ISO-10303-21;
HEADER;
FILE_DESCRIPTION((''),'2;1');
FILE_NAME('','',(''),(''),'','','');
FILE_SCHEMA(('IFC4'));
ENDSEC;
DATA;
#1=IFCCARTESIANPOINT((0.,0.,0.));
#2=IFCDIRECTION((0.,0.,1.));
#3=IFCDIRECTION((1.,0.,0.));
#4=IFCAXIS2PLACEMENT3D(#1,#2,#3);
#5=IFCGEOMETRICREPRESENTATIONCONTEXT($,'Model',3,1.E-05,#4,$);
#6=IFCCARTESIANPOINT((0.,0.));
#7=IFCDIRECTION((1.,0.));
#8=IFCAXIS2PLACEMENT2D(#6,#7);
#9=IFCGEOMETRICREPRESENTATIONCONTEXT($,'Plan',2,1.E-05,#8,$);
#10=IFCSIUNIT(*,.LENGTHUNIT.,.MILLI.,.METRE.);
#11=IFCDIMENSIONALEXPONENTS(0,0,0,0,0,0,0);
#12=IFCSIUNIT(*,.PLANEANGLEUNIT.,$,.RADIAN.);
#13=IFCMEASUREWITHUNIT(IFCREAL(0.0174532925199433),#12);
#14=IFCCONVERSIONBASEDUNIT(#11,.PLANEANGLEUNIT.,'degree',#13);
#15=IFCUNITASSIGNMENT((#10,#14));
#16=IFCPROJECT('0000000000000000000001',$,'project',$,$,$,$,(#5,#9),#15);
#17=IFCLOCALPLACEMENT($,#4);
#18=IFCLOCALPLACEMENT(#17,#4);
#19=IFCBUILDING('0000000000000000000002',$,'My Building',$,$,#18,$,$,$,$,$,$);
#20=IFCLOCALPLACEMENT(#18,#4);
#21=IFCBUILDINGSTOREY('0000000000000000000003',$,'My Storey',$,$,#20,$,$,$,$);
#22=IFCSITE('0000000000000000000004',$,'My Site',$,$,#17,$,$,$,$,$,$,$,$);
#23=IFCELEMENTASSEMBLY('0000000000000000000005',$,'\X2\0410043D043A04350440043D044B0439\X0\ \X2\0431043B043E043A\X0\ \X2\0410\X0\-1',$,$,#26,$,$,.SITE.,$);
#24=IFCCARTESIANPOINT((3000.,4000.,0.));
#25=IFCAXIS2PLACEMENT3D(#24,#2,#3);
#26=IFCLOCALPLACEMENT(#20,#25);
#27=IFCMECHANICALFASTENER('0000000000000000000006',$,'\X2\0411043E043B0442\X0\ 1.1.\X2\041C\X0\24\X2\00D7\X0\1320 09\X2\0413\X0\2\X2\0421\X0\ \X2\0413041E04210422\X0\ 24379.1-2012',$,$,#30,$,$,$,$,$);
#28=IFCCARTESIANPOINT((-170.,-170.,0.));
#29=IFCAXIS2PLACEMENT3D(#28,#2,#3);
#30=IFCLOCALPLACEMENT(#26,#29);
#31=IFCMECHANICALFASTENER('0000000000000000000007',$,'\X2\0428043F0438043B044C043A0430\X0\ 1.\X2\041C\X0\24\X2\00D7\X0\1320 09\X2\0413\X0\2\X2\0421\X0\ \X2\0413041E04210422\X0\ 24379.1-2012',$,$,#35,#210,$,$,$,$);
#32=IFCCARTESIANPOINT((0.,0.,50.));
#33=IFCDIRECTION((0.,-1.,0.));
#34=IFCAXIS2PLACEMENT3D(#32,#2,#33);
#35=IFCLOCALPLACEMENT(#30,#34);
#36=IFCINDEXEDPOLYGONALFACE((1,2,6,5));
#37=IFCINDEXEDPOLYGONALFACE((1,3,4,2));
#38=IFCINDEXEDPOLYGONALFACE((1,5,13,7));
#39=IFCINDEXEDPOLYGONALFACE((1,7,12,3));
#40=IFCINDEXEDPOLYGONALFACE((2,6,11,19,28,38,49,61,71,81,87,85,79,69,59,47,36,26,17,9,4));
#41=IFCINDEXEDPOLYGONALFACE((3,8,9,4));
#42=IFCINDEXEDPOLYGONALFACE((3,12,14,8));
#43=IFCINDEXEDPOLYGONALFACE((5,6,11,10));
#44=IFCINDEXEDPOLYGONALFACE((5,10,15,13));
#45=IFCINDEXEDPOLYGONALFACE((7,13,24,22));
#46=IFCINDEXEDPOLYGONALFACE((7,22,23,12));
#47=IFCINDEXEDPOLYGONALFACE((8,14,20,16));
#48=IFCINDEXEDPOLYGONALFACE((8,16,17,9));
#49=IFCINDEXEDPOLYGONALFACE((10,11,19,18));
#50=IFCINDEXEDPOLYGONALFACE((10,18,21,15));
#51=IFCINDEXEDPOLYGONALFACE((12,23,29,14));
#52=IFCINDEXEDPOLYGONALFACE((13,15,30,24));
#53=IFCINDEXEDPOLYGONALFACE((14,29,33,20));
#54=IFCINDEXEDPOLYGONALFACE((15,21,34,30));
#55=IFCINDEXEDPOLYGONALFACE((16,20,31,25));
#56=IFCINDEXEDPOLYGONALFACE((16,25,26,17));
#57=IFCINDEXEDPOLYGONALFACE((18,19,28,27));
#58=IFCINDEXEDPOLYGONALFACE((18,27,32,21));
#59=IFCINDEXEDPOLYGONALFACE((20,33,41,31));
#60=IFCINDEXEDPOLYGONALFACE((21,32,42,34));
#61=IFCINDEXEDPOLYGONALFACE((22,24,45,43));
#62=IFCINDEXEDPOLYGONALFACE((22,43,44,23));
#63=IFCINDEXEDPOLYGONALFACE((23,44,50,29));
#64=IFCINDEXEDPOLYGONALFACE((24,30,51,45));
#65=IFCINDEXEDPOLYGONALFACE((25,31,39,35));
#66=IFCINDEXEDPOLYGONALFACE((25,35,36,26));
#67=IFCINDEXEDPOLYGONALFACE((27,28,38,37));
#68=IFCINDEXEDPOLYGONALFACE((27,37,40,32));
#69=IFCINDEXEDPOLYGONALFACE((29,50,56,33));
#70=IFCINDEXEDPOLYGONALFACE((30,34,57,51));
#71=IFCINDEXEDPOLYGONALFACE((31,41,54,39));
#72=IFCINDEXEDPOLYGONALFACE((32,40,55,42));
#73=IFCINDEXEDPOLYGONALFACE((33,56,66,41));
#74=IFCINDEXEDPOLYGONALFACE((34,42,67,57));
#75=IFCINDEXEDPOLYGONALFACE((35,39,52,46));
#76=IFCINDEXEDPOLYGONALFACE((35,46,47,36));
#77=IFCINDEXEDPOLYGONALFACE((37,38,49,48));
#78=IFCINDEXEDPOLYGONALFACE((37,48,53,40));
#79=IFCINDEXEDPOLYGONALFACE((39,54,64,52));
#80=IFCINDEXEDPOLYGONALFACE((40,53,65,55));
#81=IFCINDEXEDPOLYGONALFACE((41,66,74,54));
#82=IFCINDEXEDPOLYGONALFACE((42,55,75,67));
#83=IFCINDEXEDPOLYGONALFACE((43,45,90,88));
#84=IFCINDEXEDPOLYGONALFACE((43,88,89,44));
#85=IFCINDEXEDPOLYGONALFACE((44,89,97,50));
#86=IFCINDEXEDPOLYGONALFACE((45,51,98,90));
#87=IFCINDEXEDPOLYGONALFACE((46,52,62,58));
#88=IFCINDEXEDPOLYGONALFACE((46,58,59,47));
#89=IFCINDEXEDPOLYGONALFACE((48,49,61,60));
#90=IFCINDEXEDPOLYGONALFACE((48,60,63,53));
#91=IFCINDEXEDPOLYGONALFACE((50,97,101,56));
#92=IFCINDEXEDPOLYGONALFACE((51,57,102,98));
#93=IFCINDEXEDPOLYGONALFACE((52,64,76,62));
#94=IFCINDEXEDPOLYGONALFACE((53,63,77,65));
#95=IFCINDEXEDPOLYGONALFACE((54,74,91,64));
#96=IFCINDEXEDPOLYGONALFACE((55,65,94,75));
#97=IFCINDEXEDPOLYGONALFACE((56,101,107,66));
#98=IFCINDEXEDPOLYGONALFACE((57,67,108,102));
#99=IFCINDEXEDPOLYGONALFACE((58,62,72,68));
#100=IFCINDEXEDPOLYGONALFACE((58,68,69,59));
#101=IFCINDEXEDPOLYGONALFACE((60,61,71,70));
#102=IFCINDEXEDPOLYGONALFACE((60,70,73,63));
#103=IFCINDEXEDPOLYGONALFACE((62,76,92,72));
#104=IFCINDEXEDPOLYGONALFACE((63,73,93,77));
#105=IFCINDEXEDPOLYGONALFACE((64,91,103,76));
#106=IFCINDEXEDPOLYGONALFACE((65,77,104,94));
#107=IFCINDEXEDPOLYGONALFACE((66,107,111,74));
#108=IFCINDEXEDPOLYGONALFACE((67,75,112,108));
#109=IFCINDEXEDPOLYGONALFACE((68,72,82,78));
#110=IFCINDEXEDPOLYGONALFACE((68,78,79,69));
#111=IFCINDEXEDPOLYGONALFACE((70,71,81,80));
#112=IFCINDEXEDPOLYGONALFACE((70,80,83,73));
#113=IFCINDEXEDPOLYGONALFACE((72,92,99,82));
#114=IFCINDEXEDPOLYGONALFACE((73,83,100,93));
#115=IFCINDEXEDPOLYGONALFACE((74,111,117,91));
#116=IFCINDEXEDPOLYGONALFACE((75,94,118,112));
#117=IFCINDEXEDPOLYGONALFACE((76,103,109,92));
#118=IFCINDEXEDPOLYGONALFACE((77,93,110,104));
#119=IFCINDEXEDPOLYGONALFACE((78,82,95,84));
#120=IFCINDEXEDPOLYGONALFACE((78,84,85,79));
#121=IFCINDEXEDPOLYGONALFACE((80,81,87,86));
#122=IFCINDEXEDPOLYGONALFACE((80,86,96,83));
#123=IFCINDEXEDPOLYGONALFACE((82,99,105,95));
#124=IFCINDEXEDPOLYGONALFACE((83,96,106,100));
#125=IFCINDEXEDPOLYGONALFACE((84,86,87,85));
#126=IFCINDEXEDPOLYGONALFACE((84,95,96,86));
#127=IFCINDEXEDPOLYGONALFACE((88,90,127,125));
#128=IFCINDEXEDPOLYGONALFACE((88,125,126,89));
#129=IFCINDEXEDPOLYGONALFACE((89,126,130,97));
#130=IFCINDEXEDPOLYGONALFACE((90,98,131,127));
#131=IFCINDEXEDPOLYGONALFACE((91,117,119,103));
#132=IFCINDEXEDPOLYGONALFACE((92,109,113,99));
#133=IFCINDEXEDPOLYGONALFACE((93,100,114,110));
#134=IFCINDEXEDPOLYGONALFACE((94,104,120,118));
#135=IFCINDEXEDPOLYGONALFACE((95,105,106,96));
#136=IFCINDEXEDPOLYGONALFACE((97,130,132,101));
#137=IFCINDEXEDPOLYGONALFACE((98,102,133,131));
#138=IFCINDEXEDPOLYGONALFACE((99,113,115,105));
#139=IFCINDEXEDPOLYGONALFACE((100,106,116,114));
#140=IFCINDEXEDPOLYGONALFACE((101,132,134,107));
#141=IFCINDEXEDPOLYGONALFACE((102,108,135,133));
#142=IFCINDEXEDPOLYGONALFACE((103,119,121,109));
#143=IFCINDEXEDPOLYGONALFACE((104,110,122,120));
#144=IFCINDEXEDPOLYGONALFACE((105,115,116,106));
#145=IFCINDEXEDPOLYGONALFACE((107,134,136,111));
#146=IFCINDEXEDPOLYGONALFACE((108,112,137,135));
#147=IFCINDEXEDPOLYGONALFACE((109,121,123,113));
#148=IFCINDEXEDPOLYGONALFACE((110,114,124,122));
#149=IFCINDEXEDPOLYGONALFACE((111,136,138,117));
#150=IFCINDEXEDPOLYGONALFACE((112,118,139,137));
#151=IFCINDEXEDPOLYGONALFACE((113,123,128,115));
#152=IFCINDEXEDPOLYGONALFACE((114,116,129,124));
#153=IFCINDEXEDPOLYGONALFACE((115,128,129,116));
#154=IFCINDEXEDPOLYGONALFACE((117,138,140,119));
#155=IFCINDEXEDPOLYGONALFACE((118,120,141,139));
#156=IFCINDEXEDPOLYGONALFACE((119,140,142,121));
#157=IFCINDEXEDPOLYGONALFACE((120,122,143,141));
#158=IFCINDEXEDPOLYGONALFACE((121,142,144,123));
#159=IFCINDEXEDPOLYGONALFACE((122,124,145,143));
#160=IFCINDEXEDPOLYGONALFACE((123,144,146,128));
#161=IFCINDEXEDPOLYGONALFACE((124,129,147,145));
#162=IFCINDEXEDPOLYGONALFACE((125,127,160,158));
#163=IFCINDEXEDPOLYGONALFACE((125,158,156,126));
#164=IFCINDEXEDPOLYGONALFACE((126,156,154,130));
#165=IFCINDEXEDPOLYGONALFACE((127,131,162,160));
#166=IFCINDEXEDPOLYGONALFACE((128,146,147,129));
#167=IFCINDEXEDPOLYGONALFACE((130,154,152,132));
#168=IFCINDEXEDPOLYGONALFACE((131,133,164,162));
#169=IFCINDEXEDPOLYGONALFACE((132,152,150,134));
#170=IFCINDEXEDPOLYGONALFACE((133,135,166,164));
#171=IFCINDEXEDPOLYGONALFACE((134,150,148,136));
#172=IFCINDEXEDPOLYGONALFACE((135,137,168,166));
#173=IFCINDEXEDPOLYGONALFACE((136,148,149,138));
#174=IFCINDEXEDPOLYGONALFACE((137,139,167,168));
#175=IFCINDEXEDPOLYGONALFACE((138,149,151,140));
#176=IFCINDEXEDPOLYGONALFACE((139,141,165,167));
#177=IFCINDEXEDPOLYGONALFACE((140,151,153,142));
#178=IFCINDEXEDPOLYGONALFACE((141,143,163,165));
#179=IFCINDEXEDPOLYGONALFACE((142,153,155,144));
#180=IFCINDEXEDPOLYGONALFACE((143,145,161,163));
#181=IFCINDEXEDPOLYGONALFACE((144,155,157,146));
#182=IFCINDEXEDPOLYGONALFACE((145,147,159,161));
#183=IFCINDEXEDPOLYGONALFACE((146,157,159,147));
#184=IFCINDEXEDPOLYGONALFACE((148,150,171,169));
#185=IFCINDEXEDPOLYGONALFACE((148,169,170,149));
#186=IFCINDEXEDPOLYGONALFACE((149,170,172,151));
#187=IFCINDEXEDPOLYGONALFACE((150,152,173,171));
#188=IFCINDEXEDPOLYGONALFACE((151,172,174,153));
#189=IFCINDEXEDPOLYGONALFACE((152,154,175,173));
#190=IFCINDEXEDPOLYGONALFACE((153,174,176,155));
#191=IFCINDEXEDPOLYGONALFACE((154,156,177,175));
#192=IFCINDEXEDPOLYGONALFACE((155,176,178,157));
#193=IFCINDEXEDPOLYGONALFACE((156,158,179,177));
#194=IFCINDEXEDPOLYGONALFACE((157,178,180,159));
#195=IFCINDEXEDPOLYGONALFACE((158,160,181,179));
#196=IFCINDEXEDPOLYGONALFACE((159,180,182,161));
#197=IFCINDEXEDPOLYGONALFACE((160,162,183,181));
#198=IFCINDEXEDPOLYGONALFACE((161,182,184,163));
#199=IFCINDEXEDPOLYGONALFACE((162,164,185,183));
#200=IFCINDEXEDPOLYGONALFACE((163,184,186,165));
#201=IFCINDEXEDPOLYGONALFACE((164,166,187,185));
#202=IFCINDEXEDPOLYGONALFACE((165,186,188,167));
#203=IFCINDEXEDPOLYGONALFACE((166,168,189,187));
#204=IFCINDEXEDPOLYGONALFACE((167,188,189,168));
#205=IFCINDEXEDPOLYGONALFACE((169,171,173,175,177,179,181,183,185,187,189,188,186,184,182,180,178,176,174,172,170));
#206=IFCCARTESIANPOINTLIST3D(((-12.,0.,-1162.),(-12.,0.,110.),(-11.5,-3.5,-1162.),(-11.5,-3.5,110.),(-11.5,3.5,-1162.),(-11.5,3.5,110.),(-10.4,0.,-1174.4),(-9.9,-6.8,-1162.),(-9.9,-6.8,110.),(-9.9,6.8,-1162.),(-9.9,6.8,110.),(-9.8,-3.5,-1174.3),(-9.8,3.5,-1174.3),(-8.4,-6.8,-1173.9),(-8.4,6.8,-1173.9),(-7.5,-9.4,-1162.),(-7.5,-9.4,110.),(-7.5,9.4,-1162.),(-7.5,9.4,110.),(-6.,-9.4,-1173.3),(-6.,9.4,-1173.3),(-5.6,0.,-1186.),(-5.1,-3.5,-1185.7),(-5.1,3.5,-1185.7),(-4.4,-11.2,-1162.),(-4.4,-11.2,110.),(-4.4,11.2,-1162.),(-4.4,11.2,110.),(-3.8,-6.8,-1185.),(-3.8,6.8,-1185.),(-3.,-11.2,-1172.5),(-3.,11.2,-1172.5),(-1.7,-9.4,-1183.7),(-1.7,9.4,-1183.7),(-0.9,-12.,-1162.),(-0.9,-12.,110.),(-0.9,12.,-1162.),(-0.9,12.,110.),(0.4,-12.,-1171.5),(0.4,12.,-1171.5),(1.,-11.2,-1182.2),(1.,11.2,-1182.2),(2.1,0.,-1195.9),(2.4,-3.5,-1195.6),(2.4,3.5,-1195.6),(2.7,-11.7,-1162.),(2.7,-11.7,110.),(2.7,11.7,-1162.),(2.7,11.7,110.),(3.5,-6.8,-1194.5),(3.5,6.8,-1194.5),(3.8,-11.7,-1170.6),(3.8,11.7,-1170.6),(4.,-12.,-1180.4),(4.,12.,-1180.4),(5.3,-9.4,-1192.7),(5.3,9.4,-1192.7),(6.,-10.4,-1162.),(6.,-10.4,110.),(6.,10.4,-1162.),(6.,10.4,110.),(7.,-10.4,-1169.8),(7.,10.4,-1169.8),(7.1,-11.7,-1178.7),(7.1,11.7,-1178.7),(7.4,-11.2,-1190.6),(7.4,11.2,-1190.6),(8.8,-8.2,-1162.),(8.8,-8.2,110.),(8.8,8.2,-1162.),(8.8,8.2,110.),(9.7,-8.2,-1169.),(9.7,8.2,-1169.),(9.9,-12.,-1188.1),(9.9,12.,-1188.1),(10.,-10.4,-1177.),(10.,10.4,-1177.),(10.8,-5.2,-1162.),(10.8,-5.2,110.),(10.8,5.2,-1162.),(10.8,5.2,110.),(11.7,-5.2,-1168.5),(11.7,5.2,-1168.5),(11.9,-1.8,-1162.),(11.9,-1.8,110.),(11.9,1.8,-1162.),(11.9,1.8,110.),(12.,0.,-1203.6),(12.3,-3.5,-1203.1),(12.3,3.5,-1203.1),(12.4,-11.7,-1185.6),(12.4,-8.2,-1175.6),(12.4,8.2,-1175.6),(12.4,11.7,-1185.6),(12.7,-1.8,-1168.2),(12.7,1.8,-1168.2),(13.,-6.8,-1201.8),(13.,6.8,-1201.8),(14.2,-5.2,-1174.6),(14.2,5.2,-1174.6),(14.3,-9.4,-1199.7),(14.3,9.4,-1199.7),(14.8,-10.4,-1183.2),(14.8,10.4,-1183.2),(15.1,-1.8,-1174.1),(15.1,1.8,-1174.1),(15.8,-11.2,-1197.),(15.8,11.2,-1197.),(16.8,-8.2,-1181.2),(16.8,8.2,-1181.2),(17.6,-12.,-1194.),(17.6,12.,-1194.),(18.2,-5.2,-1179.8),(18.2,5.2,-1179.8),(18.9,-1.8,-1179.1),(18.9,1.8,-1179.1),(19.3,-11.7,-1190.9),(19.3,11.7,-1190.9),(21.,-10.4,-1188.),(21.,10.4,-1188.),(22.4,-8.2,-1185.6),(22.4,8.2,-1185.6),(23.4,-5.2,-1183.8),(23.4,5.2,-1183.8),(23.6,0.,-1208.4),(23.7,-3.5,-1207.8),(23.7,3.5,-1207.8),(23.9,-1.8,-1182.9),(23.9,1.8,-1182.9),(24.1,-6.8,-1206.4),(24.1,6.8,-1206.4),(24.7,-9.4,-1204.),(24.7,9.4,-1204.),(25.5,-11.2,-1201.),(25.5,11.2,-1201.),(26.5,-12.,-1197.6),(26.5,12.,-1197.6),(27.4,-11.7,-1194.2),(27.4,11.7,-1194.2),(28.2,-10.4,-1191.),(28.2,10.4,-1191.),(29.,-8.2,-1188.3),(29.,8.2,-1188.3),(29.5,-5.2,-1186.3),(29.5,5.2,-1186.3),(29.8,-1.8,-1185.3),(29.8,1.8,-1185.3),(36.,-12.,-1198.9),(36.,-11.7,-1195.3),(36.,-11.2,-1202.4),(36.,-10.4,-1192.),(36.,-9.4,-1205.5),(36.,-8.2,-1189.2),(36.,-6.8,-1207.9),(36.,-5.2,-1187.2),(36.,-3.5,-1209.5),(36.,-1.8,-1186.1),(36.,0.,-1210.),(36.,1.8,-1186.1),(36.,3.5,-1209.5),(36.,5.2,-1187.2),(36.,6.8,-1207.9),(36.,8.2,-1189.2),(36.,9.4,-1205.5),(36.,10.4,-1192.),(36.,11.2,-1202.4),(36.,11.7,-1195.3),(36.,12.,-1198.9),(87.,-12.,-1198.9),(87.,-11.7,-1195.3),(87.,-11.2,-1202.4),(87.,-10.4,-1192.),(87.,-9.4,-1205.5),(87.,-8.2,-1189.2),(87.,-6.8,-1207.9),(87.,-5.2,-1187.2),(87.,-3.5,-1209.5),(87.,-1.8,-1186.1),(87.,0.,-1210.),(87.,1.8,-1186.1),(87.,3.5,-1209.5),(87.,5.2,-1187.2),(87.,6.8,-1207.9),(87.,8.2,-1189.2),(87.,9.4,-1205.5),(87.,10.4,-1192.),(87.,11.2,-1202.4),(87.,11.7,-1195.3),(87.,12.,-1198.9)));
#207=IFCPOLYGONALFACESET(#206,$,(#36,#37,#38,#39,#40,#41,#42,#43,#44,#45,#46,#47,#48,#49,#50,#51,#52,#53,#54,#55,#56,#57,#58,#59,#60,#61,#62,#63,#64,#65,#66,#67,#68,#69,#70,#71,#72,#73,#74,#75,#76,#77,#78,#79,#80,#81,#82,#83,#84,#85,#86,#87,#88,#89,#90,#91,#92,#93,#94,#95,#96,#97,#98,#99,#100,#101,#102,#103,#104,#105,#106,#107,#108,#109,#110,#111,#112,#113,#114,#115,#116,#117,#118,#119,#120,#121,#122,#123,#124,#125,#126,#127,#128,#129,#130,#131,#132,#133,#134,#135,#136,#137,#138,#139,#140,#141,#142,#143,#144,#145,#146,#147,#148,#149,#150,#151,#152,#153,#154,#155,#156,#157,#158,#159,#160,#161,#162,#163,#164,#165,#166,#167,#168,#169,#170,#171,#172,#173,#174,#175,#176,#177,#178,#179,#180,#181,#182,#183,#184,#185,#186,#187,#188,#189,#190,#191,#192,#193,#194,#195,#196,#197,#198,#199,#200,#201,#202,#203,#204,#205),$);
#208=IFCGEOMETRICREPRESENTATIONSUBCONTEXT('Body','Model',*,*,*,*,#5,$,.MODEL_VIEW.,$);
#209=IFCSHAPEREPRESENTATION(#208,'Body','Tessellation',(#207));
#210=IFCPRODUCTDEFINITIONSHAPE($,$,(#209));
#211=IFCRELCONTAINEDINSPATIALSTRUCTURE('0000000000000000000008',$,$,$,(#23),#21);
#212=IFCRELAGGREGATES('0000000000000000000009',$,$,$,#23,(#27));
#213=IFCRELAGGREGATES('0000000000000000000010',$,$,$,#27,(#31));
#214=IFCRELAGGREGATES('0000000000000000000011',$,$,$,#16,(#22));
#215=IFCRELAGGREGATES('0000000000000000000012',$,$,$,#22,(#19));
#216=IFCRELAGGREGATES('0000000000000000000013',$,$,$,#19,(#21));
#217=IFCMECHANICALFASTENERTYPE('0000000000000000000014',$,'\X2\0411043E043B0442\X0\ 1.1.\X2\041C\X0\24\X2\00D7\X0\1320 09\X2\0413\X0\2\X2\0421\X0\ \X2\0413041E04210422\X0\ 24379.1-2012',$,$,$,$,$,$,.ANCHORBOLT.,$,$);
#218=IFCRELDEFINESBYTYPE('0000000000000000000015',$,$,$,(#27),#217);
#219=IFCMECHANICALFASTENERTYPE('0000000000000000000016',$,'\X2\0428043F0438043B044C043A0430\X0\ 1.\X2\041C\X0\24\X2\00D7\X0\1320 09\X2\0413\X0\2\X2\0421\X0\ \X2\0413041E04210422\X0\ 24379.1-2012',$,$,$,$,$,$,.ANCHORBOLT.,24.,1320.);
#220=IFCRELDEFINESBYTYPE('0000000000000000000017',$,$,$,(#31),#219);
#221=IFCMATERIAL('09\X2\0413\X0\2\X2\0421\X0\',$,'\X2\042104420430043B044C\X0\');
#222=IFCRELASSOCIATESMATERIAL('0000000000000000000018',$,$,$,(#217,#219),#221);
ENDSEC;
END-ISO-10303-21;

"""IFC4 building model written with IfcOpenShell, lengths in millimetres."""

from ifc_helpers import new_model, entity, si_unit, converted_unit, frame, origin_with_axes, origin_2d_with_axis, place, context, subcontext, project, spatial, source, transform, mapped, material, type_object, type_shapes, element, aggregate, save


model = new_model("IFC4")

# Units and contexts
model_context = context("Model", 3, precision=1e-05, world=origin_with_axes())
plan_context = context("Plan", 2, precision=1e-05, world=origin_2d_with_axis())
body_context = subcontext(model_context, "Body", "Model", "MODEL_VIEW")
ifc_project = project(units=[si_unit("LENGTHUNIT", "METRE", prefix="MILLI"), converted_unit("PLANEANGLEUNIT", "degree", entity("IfcReal", 0.0174532925199433), si_unit("PLANEANGLEUNIT", "RADIAN"), dimensions=[0, 0, 0, 0, 0, 0, 0])], contexts=[model_context, plan_context])

# Site, building, storey
site_placement = place(None, origin_with_axes())
site = spatial("IfcSite", under=ifc_project, at=site_placement, Name="My Site")
building_placement = place(site_placement, origin_with_axes())
building = spatial("IfcBuilding", under=site, at=building_placement, Name="My Building")
storey_placement = place(building_placement, origin_with_axes())
storey = spatial("IfcBuildingStorey", under=building, at=storey_placement, Name="My Storey")

# Element assembly, mechanical fasteners
ifc_material_1 = material(Name="09Г2С", Category="Сталь")
mechanical_fastener_type_1 = type_object("IfcMechanicalFastenerType", Name="Болт 1.1.М24×1320 09Г2С ГОСТ 24379.1-2012", PredefinedType="ANCHORBOLT", material=ifc_material_1)
mechanical_fastener_type_2 = type_object("IfcMechanicalFastenerType", Name="Шпилька 1.М24×1320 09Г2С ГОСТ 24379.1-2012", NominalDiameter=24.0, NominalLength=1320.0, PredefinedType="ANCHORBOLT", material=ifc_material_1)
shared_shape_1 = source(frame((0.0, 0.0, 110.0), z_axis=(0.0, 0.0, 1.0), x_axis=(1.0, 0.0, 0.0)), body_context, "Body", "AdvancedSweptSolid", [
    entity("IfcSweptDiskSolid", entity("IfcIndexedPolyCurve", entity("IfcCartesianPointList3D", [[0.0, 0.0, 0.0], [0.0, 0.0, -1272.0], [10.5, 0.0, -1297.5], [36.0, 0.0, -1308.0], [87.0, 0.0, -1308.0]]), [entity("IfcLineIndex", [1, 2]), entity("IfcArcIndex", [2, 3, 4]), entity("IfcLineIndex", [4, 5])]), 12.0),
])
type_shapes(mechanical_fastener_type_2, [shared_shape_1])
assembly_1_placement = place(storey_placement, frame((3000.0, 4000.0, 0.0), z_axis=(0.0, 0.0, 1.0), x_axis=(1.0, 0.0, 0.0)))
assembly_1 = element("IfcElementAssembly", 1, at=assembly_1_placement, inside=storey, Name="Анкерный блок А-1", AssemblyPlace="SITE")
mechanical_fastener_1_placement = place(assembly_1_placement, frame((-170.0, -170.0, 0.0), z_axis=(0.0, 0.0, 1.0), x_axis=(1.0, 0.0, 0.0)))
mechanical_fastener_1 = element("IfcMechanicalFastener", 2, at=mechanical_fastener_1_placement, type_object=mechanical_fastener_type_1, Name="Болт 1.1.М24×1320 09Г2С ГОСТ 24379.1-2012")
mechanical_fastener_2_placement = place(mechanical_fastener_1_placement, frame((0.0, 0.0, 50.0), z_axis=(0.0, 0.0, 1.0), x_axis=(0.0, -1.0, 0.0)))
mechanical_fastener_2 = element("IfcMechanicalFastener", 3, at=mechanical_fastener_2_placement, type_object=mechanical_fastener_type_2, Name="Шпилька 1.М24×1320 09Г2С ГОСТ 24379.1-2012", context=body_context, shape_type="MappedRepresentation", body=[
    mapped(shared_shape_1, transform((0.0, 0.0, 0.0), x_axis=(1.0, 0.0, 0.0), y_axis=(0.0, 1.0, 0.0), z_axis=(0.0, 0.0, 1.0), scale=1.0)),
])
aggregate(assembly_1, [mechanical_fastener_1])

aggregate(mechanical_fastener_1, [mechanical_fastener_2])

save(model, "model.ifc")
